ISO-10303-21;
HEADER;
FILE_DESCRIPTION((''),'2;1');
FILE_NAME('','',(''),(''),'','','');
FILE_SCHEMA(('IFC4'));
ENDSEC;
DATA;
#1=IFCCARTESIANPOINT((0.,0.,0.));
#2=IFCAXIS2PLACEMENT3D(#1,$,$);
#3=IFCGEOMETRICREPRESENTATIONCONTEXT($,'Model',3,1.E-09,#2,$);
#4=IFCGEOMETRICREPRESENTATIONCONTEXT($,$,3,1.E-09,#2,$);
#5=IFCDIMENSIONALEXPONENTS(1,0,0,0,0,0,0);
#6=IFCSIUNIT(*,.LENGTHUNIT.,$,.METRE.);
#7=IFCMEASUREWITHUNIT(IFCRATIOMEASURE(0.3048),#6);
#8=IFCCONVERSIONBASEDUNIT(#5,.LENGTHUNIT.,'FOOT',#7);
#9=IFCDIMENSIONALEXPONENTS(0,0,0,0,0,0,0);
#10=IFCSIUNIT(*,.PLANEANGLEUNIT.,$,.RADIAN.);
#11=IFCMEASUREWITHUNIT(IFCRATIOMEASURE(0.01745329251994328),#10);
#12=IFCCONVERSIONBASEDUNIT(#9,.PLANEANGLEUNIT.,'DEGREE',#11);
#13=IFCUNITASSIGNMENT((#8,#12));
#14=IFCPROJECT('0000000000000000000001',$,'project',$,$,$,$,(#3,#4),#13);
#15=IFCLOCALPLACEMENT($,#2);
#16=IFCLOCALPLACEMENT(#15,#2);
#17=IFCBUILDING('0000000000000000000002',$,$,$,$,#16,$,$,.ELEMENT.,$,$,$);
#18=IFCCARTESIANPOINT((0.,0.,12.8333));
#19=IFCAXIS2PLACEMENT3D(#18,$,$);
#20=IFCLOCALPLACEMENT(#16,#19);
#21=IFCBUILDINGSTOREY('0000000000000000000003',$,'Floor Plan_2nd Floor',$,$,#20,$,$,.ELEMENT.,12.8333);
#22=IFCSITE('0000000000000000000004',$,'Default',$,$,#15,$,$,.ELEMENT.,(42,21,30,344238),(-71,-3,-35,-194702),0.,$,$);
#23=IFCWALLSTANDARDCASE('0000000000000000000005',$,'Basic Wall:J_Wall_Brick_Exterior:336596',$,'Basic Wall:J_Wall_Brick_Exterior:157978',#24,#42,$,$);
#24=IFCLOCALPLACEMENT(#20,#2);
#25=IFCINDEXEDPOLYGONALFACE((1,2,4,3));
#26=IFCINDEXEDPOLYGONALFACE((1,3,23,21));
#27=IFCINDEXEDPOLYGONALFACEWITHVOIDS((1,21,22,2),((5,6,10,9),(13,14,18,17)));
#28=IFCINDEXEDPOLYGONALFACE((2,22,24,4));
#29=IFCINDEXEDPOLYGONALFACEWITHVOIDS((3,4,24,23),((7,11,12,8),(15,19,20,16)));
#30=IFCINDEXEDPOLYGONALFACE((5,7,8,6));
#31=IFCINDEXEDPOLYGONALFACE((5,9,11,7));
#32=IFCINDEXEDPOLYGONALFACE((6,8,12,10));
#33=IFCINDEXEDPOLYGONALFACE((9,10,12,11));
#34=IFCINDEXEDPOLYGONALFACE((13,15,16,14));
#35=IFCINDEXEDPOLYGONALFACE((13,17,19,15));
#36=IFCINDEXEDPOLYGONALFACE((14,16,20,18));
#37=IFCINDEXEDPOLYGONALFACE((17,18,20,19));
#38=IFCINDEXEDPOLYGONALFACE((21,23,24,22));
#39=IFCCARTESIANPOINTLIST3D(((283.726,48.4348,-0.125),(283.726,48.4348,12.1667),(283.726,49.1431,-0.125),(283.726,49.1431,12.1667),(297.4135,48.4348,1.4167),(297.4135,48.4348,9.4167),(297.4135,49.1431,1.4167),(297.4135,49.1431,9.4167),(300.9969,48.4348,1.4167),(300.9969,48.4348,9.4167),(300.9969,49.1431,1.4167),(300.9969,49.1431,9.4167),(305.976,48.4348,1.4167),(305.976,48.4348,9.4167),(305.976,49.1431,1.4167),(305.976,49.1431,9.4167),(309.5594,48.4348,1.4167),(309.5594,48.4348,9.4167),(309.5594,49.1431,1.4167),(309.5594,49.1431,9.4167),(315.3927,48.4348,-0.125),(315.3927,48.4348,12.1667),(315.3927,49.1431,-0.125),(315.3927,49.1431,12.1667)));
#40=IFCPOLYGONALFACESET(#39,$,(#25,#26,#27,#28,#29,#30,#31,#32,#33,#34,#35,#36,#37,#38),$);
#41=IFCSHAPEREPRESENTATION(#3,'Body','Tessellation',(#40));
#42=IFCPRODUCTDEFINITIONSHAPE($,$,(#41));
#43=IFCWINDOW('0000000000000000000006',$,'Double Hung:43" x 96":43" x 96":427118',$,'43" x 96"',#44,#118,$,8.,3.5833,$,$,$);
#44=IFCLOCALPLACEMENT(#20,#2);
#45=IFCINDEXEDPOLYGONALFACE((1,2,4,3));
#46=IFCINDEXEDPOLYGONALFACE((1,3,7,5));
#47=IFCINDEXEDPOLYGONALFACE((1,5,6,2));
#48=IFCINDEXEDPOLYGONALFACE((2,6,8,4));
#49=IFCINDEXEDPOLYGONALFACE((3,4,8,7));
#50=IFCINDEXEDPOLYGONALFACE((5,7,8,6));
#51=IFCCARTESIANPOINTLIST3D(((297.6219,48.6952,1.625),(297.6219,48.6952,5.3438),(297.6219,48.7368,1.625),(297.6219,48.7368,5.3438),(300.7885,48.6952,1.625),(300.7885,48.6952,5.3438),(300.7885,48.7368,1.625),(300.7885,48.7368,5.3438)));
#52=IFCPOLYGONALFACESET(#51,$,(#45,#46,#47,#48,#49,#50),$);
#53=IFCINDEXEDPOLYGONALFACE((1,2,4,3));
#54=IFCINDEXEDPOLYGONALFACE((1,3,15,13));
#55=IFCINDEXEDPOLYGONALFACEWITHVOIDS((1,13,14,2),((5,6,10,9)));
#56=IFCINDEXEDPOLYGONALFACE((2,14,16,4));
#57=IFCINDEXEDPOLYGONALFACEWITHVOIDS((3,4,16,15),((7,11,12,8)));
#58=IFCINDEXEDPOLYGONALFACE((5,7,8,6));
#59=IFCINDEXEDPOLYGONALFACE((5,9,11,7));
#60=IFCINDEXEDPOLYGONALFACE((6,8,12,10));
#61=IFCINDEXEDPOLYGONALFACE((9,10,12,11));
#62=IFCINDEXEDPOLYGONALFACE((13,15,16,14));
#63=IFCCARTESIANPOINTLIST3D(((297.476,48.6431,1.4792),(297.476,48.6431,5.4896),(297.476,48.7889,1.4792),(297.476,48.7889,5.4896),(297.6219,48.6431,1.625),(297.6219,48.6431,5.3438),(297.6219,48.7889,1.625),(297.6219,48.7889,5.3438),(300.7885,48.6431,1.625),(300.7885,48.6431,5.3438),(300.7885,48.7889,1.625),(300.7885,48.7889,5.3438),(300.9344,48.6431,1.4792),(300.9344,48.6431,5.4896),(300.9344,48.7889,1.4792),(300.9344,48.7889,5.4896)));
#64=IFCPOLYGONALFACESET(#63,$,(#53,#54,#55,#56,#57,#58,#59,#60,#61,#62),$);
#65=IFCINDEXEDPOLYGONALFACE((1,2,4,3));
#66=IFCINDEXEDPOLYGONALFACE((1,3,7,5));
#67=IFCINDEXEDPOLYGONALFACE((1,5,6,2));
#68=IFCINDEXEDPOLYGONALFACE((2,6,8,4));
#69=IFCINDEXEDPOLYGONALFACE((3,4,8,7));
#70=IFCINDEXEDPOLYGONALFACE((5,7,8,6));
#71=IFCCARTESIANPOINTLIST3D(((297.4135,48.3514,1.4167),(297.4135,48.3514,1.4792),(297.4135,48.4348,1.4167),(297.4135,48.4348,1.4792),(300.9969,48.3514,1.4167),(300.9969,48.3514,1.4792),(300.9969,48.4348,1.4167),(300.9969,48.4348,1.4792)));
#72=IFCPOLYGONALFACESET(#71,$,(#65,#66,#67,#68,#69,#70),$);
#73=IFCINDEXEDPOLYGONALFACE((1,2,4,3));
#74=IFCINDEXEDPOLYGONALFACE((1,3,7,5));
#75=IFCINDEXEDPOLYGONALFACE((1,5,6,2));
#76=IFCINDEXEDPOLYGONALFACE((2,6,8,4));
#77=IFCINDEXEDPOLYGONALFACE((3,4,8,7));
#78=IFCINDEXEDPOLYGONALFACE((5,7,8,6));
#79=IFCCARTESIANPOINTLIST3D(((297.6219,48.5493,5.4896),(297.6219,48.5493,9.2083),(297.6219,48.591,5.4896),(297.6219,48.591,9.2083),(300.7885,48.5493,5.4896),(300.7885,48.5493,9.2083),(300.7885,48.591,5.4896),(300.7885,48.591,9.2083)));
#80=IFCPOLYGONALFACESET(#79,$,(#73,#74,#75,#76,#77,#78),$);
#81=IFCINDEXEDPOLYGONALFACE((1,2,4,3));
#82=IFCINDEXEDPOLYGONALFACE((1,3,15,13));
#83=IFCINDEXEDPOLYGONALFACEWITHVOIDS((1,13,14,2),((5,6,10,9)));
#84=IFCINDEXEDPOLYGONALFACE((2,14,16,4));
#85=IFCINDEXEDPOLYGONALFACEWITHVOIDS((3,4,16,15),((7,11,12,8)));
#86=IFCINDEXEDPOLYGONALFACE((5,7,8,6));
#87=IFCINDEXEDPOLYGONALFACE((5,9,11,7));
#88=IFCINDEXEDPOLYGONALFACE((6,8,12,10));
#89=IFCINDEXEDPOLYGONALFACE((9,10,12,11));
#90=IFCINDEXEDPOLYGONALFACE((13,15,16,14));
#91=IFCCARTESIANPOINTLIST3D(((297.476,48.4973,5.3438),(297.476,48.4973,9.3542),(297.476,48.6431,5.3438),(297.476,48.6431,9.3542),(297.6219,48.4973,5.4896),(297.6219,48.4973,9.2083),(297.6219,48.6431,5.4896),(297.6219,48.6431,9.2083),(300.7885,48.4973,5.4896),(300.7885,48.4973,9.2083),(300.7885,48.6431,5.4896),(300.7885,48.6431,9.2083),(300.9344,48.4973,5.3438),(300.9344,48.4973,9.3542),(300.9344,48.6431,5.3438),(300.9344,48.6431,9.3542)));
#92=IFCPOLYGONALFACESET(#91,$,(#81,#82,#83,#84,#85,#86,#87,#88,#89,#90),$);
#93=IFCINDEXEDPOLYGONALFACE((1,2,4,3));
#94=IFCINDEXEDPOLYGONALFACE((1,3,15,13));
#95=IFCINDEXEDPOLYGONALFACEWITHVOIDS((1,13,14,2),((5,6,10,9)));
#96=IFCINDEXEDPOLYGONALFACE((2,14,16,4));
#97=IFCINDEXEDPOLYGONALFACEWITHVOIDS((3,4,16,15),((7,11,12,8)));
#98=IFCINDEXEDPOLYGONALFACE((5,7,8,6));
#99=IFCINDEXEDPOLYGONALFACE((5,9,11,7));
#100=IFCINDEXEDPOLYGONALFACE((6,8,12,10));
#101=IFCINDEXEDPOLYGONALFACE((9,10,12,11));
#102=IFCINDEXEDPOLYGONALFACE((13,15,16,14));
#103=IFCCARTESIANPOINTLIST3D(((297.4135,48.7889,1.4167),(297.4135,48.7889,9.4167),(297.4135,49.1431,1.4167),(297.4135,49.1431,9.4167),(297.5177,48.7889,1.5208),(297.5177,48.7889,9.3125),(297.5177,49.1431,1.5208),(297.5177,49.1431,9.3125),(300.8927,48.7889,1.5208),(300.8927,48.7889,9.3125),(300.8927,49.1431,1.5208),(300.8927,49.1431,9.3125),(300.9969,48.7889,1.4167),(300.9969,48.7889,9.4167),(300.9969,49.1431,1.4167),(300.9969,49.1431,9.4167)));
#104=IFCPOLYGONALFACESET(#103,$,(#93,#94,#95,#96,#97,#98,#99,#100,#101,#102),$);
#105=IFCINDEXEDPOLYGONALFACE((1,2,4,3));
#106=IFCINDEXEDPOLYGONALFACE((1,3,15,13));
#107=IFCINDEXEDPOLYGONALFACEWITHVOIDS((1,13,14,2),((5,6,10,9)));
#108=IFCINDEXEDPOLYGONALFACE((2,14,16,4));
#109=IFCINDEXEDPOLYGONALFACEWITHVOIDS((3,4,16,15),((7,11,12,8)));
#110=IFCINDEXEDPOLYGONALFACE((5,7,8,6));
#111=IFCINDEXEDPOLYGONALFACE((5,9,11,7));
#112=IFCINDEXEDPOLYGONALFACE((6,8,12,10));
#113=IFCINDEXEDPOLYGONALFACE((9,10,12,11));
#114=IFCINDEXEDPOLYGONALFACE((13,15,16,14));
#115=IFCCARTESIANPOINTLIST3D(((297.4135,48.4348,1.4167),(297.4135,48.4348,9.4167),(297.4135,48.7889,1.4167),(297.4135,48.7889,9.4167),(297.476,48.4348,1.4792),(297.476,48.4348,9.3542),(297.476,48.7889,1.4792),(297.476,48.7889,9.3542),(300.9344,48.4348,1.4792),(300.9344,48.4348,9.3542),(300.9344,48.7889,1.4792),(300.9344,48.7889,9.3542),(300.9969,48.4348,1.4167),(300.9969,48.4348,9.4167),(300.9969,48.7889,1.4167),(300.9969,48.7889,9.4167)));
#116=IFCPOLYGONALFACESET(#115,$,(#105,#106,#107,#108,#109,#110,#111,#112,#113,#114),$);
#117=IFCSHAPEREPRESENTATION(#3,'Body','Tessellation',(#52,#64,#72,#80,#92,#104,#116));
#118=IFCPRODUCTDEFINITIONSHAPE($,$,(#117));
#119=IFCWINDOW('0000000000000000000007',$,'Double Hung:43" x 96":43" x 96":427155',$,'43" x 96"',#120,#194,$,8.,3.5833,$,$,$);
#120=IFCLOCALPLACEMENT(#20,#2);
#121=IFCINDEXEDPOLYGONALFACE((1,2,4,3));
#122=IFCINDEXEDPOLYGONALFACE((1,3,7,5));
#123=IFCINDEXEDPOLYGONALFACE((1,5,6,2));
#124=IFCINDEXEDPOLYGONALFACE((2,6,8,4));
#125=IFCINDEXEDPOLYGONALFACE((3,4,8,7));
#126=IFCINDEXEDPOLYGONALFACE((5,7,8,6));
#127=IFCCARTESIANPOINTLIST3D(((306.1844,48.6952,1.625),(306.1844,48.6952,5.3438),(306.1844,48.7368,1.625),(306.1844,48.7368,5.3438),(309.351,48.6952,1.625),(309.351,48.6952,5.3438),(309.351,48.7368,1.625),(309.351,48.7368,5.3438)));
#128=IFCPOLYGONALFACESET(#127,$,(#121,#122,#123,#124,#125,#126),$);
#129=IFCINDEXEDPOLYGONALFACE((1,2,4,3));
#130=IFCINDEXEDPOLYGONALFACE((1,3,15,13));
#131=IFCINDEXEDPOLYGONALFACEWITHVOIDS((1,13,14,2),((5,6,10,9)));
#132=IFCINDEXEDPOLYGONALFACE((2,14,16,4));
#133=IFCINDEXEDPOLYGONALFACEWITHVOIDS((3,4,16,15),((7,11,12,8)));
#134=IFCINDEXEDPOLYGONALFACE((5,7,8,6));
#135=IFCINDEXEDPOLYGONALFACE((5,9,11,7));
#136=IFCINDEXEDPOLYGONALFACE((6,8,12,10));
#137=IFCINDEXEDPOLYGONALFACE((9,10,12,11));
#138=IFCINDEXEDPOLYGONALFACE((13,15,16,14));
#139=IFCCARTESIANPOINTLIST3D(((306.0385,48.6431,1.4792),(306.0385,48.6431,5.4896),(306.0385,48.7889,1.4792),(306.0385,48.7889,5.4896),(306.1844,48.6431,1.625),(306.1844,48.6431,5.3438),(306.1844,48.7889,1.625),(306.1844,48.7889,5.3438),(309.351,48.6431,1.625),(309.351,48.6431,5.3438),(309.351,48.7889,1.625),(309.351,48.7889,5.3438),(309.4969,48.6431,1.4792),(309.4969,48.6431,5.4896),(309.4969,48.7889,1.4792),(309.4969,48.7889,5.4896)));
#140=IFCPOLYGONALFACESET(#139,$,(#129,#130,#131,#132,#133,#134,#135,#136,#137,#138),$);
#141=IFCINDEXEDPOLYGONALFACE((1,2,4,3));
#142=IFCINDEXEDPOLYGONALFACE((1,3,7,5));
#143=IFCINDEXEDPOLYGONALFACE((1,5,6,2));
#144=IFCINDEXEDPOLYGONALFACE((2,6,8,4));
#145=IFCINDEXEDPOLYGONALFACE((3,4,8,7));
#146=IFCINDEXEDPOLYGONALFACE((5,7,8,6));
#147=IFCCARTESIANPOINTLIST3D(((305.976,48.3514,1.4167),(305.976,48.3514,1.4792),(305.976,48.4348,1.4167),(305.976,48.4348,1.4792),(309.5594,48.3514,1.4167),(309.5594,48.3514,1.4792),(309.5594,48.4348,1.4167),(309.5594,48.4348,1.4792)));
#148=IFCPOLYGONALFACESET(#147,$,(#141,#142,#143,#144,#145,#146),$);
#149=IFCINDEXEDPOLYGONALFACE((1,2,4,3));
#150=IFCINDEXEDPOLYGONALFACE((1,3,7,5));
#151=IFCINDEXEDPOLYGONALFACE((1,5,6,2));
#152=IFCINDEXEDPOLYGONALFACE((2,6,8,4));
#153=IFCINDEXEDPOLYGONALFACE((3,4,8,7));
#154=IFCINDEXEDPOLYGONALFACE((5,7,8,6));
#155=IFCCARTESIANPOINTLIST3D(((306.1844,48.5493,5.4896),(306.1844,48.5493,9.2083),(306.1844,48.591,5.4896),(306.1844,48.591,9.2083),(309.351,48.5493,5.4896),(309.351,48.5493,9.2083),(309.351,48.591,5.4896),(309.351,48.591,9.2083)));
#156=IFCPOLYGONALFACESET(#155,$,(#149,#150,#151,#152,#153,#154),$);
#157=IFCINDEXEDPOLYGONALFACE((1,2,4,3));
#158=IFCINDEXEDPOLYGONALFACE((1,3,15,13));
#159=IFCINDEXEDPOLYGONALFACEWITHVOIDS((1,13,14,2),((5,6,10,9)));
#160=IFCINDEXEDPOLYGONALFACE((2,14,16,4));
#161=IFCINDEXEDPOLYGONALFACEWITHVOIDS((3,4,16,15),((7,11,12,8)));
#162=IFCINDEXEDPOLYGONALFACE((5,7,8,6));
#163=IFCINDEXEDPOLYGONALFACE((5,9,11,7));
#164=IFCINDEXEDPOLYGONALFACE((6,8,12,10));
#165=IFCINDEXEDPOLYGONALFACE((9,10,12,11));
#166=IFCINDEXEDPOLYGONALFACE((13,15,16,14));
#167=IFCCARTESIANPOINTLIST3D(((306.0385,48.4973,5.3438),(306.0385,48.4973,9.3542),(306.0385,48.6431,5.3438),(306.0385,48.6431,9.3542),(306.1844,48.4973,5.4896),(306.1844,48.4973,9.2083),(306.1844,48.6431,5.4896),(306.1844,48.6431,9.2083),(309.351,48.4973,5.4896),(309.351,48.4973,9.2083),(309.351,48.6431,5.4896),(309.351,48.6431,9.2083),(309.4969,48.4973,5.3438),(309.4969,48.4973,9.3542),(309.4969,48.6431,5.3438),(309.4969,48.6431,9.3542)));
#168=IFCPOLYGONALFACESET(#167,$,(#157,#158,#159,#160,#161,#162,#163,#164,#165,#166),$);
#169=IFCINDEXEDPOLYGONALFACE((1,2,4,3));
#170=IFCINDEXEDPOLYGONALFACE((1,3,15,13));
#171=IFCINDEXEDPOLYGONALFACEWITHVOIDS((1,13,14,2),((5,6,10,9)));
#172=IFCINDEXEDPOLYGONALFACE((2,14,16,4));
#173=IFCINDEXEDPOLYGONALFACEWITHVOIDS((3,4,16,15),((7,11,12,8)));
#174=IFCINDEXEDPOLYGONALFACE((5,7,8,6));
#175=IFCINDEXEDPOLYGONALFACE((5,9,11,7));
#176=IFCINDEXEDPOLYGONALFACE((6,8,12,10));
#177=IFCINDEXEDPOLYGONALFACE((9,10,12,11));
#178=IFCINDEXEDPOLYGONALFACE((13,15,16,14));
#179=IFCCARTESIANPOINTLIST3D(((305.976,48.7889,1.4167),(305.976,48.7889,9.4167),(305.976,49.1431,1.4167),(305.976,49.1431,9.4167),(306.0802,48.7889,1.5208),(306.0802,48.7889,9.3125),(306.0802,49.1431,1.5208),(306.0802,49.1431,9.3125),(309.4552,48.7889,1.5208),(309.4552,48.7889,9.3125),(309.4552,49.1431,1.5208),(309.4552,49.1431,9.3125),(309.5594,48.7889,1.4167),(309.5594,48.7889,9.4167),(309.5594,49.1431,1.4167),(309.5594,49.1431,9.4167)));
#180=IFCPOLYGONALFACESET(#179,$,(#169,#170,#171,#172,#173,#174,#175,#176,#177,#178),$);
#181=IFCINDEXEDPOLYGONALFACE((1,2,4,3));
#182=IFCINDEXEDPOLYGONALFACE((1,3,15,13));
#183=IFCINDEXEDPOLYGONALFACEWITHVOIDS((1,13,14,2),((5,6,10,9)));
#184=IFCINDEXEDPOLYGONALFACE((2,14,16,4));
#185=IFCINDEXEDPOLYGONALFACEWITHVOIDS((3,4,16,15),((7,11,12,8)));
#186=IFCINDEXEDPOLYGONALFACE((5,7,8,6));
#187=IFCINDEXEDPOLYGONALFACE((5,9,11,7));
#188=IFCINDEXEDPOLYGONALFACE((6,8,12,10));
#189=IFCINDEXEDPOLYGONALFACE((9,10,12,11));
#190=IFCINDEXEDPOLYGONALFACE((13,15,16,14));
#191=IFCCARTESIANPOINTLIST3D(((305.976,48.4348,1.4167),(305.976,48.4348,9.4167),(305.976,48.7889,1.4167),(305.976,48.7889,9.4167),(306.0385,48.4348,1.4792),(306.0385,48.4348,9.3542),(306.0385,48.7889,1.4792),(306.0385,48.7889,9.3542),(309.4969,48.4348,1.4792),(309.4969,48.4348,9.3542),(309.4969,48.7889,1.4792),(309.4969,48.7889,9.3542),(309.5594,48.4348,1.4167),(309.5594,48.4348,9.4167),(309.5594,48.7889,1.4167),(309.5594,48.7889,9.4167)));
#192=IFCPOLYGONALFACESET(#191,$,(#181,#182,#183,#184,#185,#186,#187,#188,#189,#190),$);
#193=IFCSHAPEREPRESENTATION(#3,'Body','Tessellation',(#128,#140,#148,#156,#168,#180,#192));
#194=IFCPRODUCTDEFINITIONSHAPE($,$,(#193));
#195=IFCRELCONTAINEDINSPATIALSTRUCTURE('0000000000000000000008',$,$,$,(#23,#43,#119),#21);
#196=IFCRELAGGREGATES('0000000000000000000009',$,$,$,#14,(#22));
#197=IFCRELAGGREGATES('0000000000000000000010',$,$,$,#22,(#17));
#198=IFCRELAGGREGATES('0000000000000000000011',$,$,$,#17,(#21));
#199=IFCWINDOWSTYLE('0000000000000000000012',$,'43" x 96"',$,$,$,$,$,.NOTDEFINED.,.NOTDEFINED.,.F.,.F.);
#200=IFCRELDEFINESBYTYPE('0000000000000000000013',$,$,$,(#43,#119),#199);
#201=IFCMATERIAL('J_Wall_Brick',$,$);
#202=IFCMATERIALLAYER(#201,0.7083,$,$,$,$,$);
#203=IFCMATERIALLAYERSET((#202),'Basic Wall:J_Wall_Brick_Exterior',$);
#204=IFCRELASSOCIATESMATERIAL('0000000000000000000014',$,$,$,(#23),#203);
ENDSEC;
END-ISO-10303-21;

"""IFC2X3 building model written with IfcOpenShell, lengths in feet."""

from ifc_helpers import new_model, entity, si_unit, converted_unit, frame, frame_2d, origin, origin_2d_with_axis, place, context, project, spatial, polyline, rectangle, outline, extrude, source, transform, mapped, material, layer, layer_set, layer_usage, type_object, type_shapes, element, fill, save


model = new_model("IFC2X3")

# Units and contexts
model_context = context("Model", 3, precision=1e-09, world=origin())
context_of_model = context(None, 3, precision=1e-09, world=origin())
ifc_project = project(units=[converted_unit("LENGTHUNIT", "FOOT", entity("IfcRatioMeasure", 0.3048), si_unit("LENGTHUNIT", "METRE"), dimensions=[1, 0, 0, 0, 0, 0, 0]), converted_unit("PLANEANGLEUNIT", "DEGREE", entity("IfcRatioMeasure", 0.01745329251994328), si_unit("PLANEANGLEUNIT", "RADIAN"), dimensions=[0, 0, 0, 0, 0, 0, 0])], contexts=[model_context, context_of_model])

# Site, building, storey
site_placement = place(None, origin())
site = spatial("IfcSite", under=ifc_project, at=site_placement, Name="Default", CompositionType="ELEMENT", RefLatitude=(42, 21, 30, 344238), RefLongitude=(-71, -3, -35, -194702), RefElevation=0.0)
building_placement = place(site_placement, origin())
building = spatial("IfcBuilding", under=site, at=building_placement, CompositionType="ELEMENT")
storey_placement = place(building_placement, frame((0.0, 0.0, 12.8333)))
storey = spatial("IfcBuildingStorey", under=building, at=storey_placement, Name="Floor Plan_2nd Floor", CompositionType="ELEMENT", Elevation=12.8333)

# Shared definitions
ifc_material_1 = material(Name="J_Wall_Brick")
ifc_layer_1 = layer(ifc_material_1, 0.7083)
ifc_layer_set_1 = layer_set([ifc_layer_1], Name="Basic Wall:J_Wall_Brick_Exterior")
window_style = type_object("IfcWindowStyle", Name="43\" x 96\"", ConstructionType="NOTDEFINED", OperationType="NOTDEFINED", ParameterTakesPrecedence=False, Sizeable=False)
shared_shape = source(origin(), model_context, "Body", "SweptSolid", [
    extrude(rectangle(XDim=0.0417, YDim=3.1667, at=origin_2d_with_axis()), frame((1.7917, 0.4271, 0.2083), z_axis=(0.0, 0.0, 1.0), x_axis=(0.0, -1.0, 0.0)), (0.0, 0.0, 1.0), 3.7187),
    extrude(outline(polyline([(-1.7292, -2.0052), (1.7292, -2.0052), (1.7292, 2.0052), (-1.7292, 2.0052), (-1.7292, -2.0052)]), holes=[polyline([(-1.5833, -1.8594), (-1.5833, 1.8594), (1.5833, 1.8594), (1.5833, -1.8594), (-1.5833, -1.8594)])]), frame((1.7917, 0.3542, 2.0677), z_axis=(0.0, 1.0, 0.0), x_axis=(1.0, 0.0, 0.0)), (0.0, 0.0, 1.0), 0.1458),
    extrude(rectangle(XDim=0.0833, YDim=3.5833, at=origin_2d_with_axis()), frame((1.7917, 0.75, 0.0), z_axis=(0.0, 0.0, 1.0), x_axis=(0.0, -1.0, 0.0)), (0.0, 0.0, 1.0), 0.0625),
    extrude(rectangle(XDim=0.0417, YDim=3.1667, at=origin_2d_with_axis()), frame((1.7917, 0.5729, 4.0729), z_axis=(0.0, 0.0, 1.0), x_axis=(0.0, 1.0, 0.0)), (0.0, 0.0, 1.0), 3.7187),
    extrude(outline(polyline([(-1.7292, -2.0052), (1.7292, -2.0052), (1.7292, 2.0052), (-1.7292, 2.0052), (-1.7292, -2.0052)]), holes=[polyline([(-1.5833, -1.8594), (-1.5833, 1.8594), (1.5833, 1.8594), (1.5833, -1.8594), (-1.5833, -1.8594)])]), frame((1.7917, 0.5, 5.9323), z_axis=(0.0, 1.0, 0.0), x_axis=(1.0, 0.0, 0.0)), (0.0, 0.0, 1.0), 0.1458),
    extrude(outline(polyline([(-1.7917, -4.0), (1.7917, -4.0), (1.7917, 4.0), (-1.7917, 4.0), (-1.7917, -4.0)]), holes=[polyline([(-1.6875, -3.8958), (-1.6875, 3.8958), (1.6875, 3.8958), (1.6875, -3.8958), (-1.6875, -3.8958)])]), frame((1.7917, 0.0, 4.0), z_axis=(0.0, 1.0, 0.0), x_axis=(1.0, 0.0, 0.0)), (0.0, 0.0, 1.0), 0.3542),
    extrude(outline(polyline([(-4.0, -1.7917), (4.0, -1.7917), (4.0, 1.7917), (-4.0, 1.7917), (-4.0, -1.7917)]), holes=[polyline([(-3.9375, -1.7292), (-3.9375, 1.7292), (3.9375, 1.7292), (3.9375, -1.7292), (-3.9375, -1.7292)])]), frame((1.7917, 0.3542, 4.0), z_axis=(0.0, 1.0, 0.0), x_axis=(0.0, 0.0, -1.0)), (0.0, 0.0, 1.0), 0.3542),
])
type_shapes(window_style, [shared_shape])

# Wall, openings, windows
ifc_layer_usage_1 = layer_usage(ifc_layer_set_1, "AXIS2", "NEGATIVE", 0.3542)
wall_1_placement = place(storey_placement, frame((283.726, 48.7889, -0.125)))
wall_1 = element("IfcWallStandardCase", 1, at=wall_1_placement, inside=storey, material=ifc_layer_usage_1, Name="Basic Wall:J_Wall_Brick_Exterior:336596", ObjectType="Basic Wall:J_Wall_Brick_Exterior:157978", context=model_context, shape_type="SweptSolid", body=[
    extrude(rectangle(XDim=31.6667, YDim=0.7083, at=frame_2d((15.8333, 0.0), x_axis=(-1.0, 0.0))), origin(), (0.0, 0.0, 1.0), 12.2917),
])
opening_1_placement = place(wall_1_placement, frame((17.2708, 0.3542, 1.5417)))
opening_1 = element("IfcOpeningElement", 2, at=opening_1_placement, cuts=wall_1, ObjectType="Opening", context=model_context, shape_type="SweptSolid", body=[
    extrude(rectangle(XDim=8.0, YDim=3.5833, at=frame_2d((4.0, 1.7917), x_axis=(-1.0, 0.0))), frame((0.0, 0.0, 0.0), z_axis=(0.0, -1.0, 0.0), x_axis=(0.0, 0.0, 1.0)), (0.0, 0.0, 1.0), 0.7083),
])
opening_2_placement = place(wall_1_placement, frame((25.8333, 0.3542, 1.5417)))
opening_2 = element("IfcOpeningElement", 3, at=opening_2_placement, cuts=wall_1, ObjectType="Opening", context=model_context, shape_type="SweptSolid", body=[
    extrude(rectangle(XDim=8.0, YDim=3.5833, at=frame_2d((4.0, 1.7917), x_axis=(-1.0, 0.0))), frame((0.0, 0.0, 0.0), z_axis=(0.0, -1.0, 0.0), x_axis=(0.0, 0.0, 1.0)), (0.0, 0.0, 1.0), 0.7083),
])
window_1_placement = place(opening_1_placement, frame((0.0, 0.0, 0.0), z_axis=(0.0, 0.0, 1.0), x_axis=(-1.0, 0.0, 0.0)))
window_1 = element("IfcWindow", 4, at=window_1_placement, inside=storey, type_object=window_style, Name="Double Hung:43\" x 96\":43\" x 96\":427118", ObjectType="43\" x 96\"", OverallHeight=8.0, OverallWidth=3.5833, context=model_context, shape_type="MappedRepresentation", body=[
    mapped(shared_shape, transform((0.0, 0.0, 0.0), scale=1.0)),
])
fill(opening_1, window_1)
window_2_placement = place(opening_2_placement, frame((0.0, 0.0, 0.0), z_axis=(0.0, 0.0, 1.0), x_axis=(-1.0, 0.0, 0.0)))
window_2 = element("IfcWindow", 5, at=window_2_placement, inside=storey, type_object=window_style, Name="Double Hung:43\" x 96\":43\" x 96\":427155", ObjectType="43\" x 96\"", OverallHeight=8.0, OverallWidth=3.5833, context=model_context, shape_type="MappedRepresentation", body=[
    mapped(shared_shape, transform((0.0, 0.0, 0.0), scale=1.0)),
])
fill(opening_2, window_2)

save(model, "model.ifc")
